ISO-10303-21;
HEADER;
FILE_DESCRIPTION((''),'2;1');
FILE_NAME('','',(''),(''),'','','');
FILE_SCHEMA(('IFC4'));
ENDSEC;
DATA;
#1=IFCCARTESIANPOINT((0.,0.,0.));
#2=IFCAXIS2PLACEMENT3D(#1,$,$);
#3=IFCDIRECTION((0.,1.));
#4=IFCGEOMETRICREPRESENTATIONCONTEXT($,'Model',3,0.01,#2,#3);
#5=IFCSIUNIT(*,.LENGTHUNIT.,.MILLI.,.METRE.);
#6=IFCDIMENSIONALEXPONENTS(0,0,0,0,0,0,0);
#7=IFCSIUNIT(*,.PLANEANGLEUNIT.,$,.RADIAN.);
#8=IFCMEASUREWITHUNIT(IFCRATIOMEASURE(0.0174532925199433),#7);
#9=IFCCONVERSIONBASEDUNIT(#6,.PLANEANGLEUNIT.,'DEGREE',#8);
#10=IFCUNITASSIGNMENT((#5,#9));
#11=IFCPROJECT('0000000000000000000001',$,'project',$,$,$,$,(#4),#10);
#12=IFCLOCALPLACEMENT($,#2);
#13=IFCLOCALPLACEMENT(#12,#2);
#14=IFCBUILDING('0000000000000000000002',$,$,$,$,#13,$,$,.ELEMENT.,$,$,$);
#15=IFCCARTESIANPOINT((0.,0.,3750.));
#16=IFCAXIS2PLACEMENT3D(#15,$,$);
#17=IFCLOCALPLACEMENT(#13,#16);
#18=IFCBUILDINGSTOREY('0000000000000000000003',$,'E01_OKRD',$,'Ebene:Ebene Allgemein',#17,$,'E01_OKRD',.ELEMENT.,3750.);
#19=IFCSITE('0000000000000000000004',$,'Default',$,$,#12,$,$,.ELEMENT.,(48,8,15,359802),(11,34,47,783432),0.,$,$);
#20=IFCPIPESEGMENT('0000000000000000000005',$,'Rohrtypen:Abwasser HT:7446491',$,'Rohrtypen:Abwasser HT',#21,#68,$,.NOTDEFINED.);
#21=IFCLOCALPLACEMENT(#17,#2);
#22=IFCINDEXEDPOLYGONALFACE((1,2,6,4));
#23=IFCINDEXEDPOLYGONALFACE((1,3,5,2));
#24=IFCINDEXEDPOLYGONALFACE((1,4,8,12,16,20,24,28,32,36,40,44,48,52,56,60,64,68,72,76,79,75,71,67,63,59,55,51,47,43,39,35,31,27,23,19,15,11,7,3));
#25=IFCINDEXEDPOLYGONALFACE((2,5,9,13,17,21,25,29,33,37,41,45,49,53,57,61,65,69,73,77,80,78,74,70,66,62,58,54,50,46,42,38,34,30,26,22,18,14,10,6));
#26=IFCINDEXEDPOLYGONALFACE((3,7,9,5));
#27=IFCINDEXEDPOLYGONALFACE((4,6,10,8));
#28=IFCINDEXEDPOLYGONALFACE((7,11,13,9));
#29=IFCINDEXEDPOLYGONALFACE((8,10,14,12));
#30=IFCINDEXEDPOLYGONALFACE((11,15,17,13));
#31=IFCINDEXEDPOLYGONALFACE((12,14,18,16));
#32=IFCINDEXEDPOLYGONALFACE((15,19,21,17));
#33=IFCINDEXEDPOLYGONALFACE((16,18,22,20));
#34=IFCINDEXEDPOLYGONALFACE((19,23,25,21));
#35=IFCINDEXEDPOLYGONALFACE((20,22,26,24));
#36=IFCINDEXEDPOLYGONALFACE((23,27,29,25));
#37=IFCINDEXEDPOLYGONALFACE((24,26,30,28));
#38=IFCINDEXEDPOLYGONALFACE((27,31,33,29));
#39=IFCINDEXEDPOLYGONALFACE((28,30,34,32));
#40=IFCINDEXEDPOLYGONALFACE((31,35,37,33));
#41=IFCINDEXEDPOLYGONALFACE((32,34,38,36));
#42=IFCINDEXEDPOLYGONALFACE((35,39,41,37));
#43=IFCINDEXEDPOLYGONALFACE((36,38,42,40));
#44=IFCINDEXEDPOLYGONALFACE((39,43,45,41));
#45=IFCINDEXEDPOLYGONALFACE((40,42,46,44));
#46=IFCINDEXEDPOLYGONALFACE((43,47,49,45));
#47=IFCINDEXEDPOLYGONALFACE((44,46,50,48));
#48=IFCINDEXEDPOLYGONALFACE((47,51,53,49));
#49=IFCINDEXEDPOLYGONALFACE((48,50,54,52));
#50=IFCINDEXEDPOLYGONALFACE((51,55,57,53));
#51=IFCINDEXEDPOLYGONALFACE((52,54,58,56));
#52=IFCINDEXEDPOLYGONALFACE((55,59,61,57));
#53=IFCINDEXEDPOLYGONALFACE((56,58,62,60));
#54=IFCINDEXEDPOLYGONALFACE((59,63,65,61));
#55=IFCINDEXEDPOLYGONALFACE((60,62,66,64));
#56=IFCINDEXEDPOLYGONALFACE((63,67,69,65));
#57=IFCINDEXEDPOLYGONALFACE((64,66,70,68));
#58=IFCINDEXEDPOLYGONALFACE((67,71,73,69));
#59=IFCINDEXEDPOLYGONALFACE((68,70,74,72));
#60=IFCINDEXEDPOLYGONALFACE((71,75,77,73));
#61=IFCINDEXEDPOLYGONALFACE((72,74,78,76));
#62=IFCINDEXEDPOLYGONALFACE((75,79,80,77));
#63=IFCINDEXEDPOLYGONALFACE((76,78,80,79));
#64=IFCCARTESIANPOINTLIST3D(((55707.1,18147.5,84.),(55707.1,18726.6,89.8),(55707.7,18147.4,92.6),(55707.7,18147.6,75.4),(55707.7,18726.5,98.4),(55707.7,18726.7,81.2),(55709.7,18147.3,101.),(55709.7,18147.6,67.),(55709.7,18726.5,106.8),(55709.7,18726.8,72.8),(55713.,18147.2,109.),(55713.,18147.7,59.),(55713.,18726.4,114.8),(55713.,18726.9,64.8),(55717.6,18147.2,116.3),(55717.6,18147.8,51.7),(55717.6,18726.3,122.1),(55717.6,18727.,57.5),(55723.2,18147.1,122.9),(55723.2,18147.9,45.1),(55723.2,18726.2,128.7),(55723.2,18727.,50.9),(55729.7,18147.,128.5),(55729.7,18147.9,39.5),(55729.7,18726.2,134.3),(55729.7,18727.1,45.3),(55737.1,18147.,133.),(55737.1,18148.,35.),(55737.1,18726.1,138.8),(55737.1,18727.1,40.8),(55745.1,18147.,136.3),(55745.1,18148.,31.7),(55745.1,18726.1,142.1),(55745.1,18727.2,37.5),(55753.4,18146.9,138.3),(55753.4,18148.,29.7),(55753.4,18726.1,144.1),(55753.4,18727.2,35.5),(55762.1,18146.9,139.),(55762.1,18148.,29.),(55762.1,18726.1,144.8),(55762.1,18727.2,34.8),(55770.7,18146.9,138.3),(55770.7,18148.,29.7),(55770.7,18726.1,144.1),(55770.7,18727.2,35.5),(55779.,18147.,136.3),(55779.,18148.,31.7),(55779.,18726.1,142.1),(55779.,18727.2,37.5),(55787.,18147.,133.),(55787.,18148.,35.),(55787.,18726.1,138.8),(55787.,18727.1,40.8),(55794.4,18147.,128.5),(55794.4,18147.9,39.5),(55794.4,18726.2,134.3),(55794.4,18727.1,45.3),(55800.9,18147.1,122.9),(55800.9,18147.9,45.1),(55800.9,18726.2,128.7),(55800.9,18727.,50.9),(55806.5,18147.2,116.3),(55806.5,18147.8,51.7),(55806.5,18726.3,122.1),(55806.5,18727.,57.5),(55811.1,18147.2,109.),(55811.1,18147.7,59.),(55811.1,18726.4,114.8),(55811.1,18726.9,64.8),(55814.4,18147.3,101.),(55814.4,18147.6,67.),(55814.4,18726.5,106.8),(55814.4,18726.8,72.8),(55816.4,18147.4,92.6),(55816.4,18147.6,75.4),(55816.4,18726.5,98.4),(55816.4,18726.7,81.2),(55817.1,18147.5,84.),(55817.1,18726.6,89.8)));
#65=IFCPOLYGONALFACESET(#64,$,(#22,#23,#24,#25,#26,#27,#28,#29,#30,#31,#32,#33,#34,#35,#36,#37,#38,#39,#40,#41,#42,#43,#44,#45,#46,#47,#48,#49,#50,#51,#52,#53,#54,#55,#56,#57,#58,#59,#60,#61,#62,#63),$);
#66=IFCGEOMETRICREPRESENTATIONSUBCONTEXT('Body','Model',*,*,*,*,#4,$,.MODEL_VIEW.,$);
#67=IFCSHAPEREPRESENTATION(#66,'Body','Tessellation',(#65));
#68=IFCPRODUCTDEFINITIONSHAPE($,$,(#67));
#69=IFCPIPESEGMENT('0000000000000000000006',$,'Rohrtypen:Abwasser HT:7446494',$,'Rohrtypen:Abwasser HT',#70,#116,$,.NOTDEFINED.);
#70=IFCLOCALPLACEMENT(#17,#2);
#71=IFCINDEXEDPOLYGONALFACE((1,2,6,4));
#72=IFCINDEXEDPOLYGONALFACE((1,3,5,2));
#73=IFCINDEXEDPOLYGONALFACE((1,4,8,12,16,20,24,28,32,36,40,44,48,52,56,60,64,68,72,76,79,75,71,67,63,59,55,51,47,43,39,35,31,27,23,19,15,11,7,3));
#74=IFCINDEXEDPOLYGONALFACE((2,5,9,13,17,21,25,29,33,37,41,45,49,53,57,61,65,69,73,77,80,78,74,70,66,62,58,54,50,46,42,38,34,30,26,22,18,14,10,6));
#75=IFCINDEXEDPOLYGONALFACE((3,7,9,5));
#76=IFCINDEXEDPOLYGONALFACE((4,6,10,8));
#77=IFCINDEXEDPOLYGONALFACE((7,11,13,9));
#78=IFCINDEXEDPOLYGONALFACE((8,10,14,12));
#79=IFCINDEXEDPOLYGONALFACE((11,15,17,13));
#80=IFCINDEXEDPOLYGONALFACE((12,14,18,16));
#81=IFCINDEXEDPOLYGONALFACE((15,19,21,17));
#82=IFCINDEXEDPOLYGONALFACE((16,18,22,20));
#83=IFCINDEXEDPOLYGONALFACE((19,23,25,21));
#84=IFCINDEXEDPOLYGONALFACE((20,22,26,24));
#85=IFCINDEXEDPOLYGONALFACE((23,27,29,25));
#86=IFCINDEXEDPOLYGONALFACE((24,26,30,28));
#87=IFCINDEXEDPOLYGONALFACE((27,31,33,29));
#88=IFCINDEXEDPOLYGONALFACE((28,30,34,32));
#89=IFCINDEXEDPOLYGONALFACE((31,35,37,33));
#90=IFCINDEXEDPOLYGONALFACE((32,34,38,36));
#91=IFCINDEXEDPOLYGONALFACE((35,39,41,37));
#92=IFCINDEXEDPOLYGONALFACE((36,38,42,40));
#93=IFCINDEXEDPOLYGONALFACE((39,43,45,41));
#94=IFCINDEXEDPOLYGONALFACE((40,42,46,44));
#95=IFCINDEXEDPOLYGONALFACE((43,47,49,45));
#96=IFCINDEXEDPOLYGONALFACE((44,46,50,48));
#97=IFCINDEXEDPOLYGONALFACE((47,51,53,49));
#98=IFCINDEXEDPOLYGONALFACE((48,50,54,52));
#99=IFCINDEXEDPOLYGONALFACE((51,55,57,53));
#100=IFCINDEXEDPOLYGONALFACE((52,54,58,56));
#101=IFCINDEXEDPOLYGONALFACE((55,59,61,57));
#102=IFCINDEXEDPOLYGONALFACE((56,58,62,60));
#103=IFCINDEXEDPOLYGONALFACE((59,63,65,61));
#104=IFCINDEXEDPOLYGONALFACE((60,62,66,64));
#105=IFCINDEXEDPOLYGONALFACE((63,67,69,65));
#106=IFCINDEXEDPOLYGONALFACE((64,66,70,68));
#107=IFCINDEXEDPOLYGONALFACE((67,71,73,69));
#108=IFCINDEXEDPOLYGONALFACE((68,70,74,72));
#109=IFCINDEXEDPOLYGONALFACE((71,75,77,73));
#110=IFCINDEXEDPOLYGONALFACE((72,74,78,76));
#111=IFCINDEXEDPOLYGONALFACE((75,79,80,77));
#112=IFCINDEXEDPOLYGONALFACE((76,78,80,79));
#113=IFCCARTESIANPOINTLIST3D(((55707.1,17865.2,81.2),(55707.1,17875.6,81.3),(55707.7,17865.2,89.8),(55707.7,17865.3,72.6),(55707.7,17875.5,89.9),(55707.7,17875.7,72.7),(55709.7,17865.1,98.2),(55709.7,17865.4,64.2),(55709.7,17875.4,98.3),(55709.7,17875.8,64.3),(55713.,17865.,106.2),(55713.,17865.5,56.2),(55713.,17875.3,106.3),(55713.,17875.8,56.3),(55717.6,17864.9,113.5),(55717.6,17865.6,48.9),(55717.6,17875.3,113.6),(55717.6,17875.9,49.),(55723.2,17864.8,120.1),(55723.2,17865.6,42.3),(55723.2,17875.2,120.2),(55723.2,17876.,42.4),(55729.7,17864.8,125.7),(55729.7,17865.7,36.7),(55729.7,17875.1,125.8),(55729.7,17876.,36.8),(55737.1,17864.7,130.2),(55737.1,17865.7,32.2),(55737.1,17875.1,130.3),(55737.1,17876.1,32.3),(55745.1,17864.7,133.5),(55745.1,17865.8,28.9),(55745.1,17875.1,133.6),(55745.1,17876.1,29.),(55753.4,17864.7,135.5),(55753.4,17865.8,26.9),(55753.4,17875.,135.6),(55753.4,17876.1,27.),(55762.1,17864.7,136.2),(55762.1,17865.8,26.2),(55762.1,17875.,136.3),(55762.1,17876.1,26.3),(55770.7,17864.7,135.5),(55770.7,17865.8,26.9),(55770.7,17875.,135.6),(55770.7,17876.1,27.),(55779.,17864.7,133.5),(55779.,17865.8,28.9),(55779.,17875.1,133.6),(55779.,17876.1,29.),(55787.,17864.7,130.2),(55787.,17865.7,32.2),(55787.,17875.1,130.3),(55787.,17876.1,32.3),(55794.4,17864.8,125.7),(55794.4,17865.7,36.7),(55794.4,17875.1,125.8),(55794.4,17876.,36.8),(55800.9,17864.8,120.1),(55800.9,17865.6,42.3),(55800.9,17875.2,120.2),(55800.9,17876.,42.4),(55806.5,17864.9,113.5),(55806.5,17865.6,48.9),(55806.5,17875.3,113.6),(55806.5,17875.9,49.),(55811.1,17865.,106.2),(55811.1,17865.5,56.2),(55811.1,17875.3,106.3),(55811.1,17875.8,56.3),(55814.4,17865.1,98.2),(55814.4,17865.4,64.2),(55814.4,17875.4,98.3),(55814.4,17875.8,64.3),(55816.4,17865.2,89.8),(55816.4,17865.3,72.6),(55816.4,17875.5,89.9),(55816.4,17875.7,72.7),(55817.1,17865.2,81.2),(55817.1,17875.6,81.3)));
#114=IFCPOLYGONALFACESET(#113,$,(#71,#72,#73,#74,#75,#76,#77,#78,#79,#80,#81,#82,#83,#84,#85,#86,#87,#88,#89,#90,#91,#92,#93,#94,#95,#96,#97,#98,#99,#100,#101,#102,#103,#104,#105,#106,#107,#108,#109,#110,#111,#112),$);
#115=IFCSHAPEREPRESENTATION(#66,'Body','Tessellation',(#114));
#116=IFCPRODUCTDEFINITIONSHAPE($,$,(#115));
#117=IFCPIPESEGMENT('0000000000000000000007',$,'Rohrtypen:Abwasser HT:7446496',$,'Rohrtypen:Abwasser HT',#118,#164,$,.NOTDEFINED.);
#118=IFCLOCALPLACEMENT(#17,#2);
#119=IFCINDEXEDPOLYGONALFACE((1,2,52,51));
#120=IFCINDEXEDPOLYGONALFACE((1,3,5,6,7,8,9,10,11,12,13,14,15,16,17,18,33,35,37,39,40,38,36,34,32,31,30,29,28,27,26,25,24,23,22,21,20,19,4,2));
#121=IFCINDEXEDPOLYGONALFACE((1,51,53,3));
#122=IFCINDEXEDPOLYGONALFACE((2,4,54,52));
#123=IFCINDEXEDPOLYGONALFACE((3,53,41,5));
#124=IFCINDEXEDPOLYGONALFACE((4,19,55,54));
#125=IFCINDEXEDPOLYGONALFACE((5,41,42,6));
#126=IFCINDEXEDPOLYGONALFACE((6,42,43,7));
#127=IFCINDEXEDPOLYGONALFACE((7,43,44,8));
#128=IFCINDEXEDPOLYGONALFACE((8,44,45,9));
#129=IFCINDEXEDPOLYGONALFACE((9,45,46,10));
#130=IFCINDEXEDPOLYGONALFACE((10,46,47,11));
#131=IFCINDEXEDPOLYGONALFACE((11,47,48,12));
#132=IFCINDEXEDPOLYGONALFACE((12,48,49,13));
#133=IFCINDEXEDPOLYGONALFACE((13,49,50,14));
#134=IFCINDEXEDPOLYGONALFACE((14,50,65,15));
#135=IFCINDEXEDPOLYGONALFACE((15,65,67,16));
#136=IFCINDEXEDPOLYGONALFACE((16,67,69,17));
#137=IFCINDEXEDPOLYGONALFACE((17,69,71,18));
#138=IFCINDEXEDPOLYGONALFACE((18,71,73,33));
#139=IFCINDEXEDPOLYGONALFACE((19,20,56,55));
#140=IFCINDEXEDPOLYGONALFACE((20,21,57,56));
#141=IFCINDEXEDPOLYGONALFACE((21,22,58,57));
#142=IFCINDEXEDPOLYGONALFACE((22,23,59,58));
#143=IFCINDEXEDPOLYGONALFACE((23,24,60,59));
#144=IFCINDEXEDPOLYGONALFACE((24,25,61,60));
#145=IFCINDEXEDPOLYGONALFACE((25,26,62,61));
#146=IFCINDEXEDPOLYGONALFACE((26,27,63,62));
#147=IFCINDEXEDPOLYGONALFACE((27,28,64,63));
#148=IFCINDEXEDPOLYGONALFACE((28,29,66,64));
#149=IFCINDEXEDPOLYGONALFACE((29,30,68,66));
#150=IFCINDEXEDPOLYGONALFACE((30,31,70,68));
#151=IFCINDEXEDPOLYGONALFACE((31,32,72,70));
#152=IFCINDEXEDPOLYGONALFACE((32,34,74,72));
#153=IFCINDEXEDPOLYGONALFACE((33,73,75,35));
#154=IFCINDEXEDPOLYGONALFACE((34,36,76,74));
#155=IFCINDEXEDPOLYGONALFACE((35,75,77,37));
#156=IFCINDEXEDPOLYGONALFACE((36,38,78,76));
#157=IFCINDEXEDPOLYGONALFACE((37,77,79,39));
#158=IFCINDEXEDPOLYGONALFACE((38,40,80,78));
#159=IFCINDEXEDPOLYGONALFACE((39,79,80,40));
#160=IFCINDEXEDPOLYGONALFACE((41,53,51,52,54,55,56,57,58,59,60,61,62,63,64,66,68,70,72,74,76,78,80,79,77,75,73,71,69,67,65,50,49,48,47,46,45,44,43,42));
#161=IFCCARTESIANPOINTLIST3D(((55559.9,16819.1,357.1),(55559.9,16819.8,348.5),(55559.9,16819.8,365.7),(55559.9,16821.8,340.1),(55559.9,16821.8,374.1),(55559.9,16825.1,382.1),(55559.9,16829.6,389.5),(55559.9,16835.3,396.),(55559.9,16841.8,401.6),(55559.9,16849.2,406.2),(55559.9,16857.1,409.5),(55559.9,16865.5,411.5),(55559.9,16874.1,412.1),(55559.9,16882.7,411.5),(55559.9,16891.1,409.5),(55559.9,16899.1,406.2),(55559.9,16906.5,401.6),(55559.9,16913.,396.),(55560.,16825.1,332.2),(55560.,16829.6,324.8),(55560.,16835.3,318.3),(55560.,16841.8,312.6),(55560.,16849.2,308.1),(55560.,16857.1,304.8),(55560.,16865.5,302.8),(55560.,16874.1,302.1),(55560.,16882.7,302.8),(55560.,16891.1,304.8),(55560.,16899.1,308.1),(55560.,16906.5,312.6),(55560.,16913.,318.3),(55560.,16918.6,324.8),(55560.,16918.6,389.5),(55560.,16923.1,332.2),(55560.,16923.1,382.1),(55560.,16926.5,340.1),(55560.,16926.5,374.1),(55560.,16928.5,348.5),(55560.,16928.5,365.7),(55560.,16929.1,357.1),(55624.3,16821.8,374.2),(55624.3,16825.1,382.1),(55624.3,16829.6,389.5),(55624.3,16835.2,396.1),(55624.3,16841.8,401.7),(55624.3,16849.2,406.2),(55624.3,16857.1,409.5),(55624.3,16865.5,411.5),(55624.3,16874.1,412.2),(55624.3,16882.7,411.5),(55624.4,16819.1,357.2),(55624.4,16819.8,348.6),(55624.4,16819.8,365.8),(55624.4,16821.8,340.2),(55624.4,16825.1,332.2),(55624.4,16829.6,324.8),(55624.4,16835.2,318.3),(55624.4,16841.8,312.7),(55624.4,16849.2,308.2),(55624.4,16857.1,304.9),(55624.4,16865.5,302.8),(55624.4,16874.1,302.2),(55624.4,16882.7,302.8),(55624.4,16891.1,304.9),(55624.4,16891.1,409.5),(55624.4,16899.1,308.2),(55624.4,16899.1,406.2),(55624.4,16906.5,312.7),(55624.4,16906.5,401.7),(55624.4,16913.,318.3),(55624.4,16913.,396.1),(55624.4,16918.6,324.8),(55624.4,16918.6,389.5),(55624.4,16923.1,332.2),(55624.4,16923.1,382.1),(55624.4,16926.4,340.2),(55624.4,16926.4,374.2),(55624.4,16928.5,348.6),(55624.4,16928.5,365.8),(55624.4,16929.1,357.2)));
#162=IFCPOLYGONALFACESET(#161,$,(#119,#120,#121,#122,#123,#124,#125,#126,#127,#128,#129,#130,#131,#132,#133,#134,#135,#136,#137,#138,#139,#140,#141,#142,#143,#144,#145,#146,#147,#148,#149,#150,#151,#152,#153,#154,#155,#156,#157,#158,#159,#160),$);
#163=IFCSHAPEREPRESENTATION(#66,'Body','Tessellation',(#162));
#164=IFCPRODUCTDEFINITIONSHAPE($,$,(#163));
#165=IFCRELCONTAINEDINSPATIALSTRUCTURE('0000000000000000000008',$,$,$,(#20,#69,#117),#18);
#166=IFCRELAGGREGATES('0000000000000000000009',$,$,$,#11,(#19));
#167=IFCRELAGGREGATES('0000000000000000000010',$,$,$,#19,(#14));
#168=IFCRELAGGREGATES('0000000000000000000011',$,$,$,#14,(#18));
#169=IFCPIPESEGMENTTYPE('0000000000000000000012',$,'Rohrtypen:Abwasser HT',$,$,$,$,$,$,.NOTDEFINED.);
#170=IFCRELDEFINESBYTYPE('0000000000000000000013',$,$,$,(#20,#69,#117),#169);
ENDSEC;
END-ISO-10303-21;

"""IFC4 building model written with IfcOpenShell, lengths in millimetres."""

from ifc_helpers import new_model, entity, si_unit, converted_unit, direction, frame, origin, place, context, subcontext, project, spatial, indexed_curve, outline, extrude, type_object, element, save


model = new_model("IFC4")

# Units and contexts
model_context = context("Model", 3, precision=0.01, world=origin(), true_north=direction((0.0, 1.0)))
body_context = subcontext(model_context, "Body", "Model", "MODEL_VIEW")
ifc_project = project(units=[si_unit("LENGTHUNIT", "METRE", prefix="MILLI"), converted_unit("PLANEANGLEUNIT", "DEGREE", entity("IfcRatioMeasure", 0.0174532925199433), si_unit("PLANEANGLEUNIT", "RADIAN"), dimensions=[0, 0, 0, 0, 0, 0, 0])], contexts=[model_context])

# Site, building, storey
site_placement = place(None, origin())
site = spatial("IfcSite", under=ifc_project, at=site_placement, Name="Default", CompositionType="ELEMENT", RefLatitude=(48, 8, 15, 359802), RefLongitude=(11, 34, 47, 783432), RefElevation=0.0)
building_placement = place(site_placement, origin())
building = spatial("IfcBuilding", under=site, at=building_placement, CompositionType="ELEMENT")
storey_placement = place(building_placement, frame((0.0, 0.0, 3750.0)))
storey = spatial("IfcBuildingStorey", under=building, at=storey_placement, Name="E01_OKRD", ObjectType="Ebene:Ebene Allgemein", LongName="E01_OKRD", CompositionType="ELEMENT", Elevation=3750.0)

# Pipe segments
pipe_segment_type_1 = type_object("IfcPipeSegmentType", Name="Rohrtypen:Abwasser HT", PredefinedType="NOTDEFINED")
pipe_segment_1_placement = place(storey_placement, origin())
element("IfcPipeSegment", 1, at=pipe_segment_1_placement, inside=storey, type_object=pipe_segment_type_1, Name="Rohrtypen:Abwasser HT:7446491", ObjectType="Rohrtypen:Abwasser HT", PredefinedType="NOTDEFINED", context=body_context, shape_type="SweptSolid", body=[
    extrude(outline(indexed_curve([(55.0, 0.0), (54.3, 8.6), (52.3, 17.0), (49.0, 25.0), (44.5, 32.3), (38.9, 38.9), (32.3, 44.5), (25.0, 49.0), (17.0, 52.3), (8.6, 54.3), (0.0, 55.0), (-8.6, 54.3), (-17.0, 52.3), (-25.0, 49.0), (-32.3, 44.5), (-38.9, 38.9), (-44.5, 32.3), (-49.0, 25.0), (-52.3, 17.0), (-54.3, 8.6), (-55.0, 0.0), (-54.3, -8.6), (-52.3, -17.0), (-49.0, -25.0), (-44.5, -32.3), (-38.9, -38.9), (-32.3, -44.5), (-25.0, -49.0), (-17.0, -52.3), (-8.6, -54.3), (0.0, -55.0), (8.6, -54.3), (17.0, -52.3), (25.0, -49.0), (32.3, -44.5), (38.9, -38.9), (44.5, -32.3), (49.0, -25.0), (52.3, -17.0), (54.3, -8.6), (55.0, 0.0)], self_intersect=False)), frame((55762.1, 18147.5, 84.0), z_axis=(0.0, 0.99995, 0.01), x_axis=(-1.0, 0.0, 0.0)), (0.0, 0.0, 1.0), 579.2),
])
pipe_segment_2_placement = place(storey_placement, origin())
element("IfcPipeSegment", 2, at=pipe_segment_2_placement, inside=storey, type_object=pipe_segment_type_1, Name="Rohrtypen:Abwasser HT:7446494", ObjectType="Rohrtypen:Abwasser HT", PredefinedType="NOTDEFINED", context=body_context, shape_type="SweptSolid", body=[
    extrude(outline(indexed_curve([(55.0, 0.0), (54.3, 8.6), (52.3, 17.0), (49.0, 25.0), (44.5, 32.3), (38.9, 38.9), (32.3, 44.5), (25.0, 49.0), (17.0, 52.3), (8.6, 54.3), (0.0, 55.0), (-8.6, 54.3), (-17.0, 52.3), (-25.0, 49.0), (-32.3, 44.5), (-38.9, 38.9), (-44.5, 32.3), (-49.0, 25.0), (-52.3, 17.0), (-54.3, 8.6), (-55.0, 0.0), (-54.3, -8.6), (-52.3, -17.0), (-49.0, -25.0), (-44.5, -32.3), (-38.9, -38.9), (-32.3, -44.5), (-25.0, -49.0), (-17.0, -52.3), (-8.6, -54.3), (0.0, -55.0), (8.6, -54.3), (17.0, -52.3), (25.0, -49.0), (32.3, -44.5), (38.9, -38.9), (44.5, -32.3), (49.0, -25.0), (52.3, -17.0), (54.3, -8.6), (55.0, 0.0)], self_intersect=False)), frame((55762.1, 17865.2, 81.2), z_axis=(0.0, 0.99995, 0.01), x_axis=(-1.0, 0.0, 0.0)), (0.0, 0.0, 1.0), 10.4),
])
pipe_segment_3_placement = place(storey_placement, origin())
element("IfcPipeSegment", 3, at=pipe_segment_3_placement, inside=storey, type_object=pipe_segment_type_1, Name="Rohrtypen:Abwasser HT:7446496", ObjectType="Rohrtypen:Abwasser HT", PredefinedType="NOTDEFINED", context=body_context, shape_type="SweptSolid", body=[
    extrude(outline(indexed_curve([(55.0, 0.0), (54.3, 8.6), (52.3, 17.0), (49.0, 25.0), (44.5, 32.3), (38.9, 38.9), (32.3, 44.5), (25.0, 49.0), (17.0, 52.3), (8.6, 54.3), (0.0, 55.0), (-8.6, 54.3), (-17.0, 52.3), (-25.0, 49.0), (-32.3, 44.5), (-38.9, 38.9), (-44.5, 32.3), (-49.0, 25.0), (-52.3, 17.0), (-54.3, 8.6), (-55.0, 0.0), (-54.3, -8.6), (-52.3, -17.0), (-49.0, -25.0), (-44.5, -32.3), (-38.9, -38.9), (-32.3, -44.5), (-25.0, -49.0), (-17.0, -52.3), (-8.6, -54.3), (0.0, -55.0), (8.6, -54.3), (17.0, -52.3), (25.0, -49.0), (32.3, -44.5), (38.9, -38.9), (44.5, -32.3), (49.0, -25.0), (52.3, -17.0), (54.3, -8.6), (55.0, 0.0)], self_intersect=False)), frame((55624.4, 16874.1, 357.2), z_axis=(-1.0, 0.000208, -0.000342), x_axis=(-0.000208, -1.0, 0.0)), (0.0, 0.0, 1.0), 64.4),
])

save(model, "model.ifc")
